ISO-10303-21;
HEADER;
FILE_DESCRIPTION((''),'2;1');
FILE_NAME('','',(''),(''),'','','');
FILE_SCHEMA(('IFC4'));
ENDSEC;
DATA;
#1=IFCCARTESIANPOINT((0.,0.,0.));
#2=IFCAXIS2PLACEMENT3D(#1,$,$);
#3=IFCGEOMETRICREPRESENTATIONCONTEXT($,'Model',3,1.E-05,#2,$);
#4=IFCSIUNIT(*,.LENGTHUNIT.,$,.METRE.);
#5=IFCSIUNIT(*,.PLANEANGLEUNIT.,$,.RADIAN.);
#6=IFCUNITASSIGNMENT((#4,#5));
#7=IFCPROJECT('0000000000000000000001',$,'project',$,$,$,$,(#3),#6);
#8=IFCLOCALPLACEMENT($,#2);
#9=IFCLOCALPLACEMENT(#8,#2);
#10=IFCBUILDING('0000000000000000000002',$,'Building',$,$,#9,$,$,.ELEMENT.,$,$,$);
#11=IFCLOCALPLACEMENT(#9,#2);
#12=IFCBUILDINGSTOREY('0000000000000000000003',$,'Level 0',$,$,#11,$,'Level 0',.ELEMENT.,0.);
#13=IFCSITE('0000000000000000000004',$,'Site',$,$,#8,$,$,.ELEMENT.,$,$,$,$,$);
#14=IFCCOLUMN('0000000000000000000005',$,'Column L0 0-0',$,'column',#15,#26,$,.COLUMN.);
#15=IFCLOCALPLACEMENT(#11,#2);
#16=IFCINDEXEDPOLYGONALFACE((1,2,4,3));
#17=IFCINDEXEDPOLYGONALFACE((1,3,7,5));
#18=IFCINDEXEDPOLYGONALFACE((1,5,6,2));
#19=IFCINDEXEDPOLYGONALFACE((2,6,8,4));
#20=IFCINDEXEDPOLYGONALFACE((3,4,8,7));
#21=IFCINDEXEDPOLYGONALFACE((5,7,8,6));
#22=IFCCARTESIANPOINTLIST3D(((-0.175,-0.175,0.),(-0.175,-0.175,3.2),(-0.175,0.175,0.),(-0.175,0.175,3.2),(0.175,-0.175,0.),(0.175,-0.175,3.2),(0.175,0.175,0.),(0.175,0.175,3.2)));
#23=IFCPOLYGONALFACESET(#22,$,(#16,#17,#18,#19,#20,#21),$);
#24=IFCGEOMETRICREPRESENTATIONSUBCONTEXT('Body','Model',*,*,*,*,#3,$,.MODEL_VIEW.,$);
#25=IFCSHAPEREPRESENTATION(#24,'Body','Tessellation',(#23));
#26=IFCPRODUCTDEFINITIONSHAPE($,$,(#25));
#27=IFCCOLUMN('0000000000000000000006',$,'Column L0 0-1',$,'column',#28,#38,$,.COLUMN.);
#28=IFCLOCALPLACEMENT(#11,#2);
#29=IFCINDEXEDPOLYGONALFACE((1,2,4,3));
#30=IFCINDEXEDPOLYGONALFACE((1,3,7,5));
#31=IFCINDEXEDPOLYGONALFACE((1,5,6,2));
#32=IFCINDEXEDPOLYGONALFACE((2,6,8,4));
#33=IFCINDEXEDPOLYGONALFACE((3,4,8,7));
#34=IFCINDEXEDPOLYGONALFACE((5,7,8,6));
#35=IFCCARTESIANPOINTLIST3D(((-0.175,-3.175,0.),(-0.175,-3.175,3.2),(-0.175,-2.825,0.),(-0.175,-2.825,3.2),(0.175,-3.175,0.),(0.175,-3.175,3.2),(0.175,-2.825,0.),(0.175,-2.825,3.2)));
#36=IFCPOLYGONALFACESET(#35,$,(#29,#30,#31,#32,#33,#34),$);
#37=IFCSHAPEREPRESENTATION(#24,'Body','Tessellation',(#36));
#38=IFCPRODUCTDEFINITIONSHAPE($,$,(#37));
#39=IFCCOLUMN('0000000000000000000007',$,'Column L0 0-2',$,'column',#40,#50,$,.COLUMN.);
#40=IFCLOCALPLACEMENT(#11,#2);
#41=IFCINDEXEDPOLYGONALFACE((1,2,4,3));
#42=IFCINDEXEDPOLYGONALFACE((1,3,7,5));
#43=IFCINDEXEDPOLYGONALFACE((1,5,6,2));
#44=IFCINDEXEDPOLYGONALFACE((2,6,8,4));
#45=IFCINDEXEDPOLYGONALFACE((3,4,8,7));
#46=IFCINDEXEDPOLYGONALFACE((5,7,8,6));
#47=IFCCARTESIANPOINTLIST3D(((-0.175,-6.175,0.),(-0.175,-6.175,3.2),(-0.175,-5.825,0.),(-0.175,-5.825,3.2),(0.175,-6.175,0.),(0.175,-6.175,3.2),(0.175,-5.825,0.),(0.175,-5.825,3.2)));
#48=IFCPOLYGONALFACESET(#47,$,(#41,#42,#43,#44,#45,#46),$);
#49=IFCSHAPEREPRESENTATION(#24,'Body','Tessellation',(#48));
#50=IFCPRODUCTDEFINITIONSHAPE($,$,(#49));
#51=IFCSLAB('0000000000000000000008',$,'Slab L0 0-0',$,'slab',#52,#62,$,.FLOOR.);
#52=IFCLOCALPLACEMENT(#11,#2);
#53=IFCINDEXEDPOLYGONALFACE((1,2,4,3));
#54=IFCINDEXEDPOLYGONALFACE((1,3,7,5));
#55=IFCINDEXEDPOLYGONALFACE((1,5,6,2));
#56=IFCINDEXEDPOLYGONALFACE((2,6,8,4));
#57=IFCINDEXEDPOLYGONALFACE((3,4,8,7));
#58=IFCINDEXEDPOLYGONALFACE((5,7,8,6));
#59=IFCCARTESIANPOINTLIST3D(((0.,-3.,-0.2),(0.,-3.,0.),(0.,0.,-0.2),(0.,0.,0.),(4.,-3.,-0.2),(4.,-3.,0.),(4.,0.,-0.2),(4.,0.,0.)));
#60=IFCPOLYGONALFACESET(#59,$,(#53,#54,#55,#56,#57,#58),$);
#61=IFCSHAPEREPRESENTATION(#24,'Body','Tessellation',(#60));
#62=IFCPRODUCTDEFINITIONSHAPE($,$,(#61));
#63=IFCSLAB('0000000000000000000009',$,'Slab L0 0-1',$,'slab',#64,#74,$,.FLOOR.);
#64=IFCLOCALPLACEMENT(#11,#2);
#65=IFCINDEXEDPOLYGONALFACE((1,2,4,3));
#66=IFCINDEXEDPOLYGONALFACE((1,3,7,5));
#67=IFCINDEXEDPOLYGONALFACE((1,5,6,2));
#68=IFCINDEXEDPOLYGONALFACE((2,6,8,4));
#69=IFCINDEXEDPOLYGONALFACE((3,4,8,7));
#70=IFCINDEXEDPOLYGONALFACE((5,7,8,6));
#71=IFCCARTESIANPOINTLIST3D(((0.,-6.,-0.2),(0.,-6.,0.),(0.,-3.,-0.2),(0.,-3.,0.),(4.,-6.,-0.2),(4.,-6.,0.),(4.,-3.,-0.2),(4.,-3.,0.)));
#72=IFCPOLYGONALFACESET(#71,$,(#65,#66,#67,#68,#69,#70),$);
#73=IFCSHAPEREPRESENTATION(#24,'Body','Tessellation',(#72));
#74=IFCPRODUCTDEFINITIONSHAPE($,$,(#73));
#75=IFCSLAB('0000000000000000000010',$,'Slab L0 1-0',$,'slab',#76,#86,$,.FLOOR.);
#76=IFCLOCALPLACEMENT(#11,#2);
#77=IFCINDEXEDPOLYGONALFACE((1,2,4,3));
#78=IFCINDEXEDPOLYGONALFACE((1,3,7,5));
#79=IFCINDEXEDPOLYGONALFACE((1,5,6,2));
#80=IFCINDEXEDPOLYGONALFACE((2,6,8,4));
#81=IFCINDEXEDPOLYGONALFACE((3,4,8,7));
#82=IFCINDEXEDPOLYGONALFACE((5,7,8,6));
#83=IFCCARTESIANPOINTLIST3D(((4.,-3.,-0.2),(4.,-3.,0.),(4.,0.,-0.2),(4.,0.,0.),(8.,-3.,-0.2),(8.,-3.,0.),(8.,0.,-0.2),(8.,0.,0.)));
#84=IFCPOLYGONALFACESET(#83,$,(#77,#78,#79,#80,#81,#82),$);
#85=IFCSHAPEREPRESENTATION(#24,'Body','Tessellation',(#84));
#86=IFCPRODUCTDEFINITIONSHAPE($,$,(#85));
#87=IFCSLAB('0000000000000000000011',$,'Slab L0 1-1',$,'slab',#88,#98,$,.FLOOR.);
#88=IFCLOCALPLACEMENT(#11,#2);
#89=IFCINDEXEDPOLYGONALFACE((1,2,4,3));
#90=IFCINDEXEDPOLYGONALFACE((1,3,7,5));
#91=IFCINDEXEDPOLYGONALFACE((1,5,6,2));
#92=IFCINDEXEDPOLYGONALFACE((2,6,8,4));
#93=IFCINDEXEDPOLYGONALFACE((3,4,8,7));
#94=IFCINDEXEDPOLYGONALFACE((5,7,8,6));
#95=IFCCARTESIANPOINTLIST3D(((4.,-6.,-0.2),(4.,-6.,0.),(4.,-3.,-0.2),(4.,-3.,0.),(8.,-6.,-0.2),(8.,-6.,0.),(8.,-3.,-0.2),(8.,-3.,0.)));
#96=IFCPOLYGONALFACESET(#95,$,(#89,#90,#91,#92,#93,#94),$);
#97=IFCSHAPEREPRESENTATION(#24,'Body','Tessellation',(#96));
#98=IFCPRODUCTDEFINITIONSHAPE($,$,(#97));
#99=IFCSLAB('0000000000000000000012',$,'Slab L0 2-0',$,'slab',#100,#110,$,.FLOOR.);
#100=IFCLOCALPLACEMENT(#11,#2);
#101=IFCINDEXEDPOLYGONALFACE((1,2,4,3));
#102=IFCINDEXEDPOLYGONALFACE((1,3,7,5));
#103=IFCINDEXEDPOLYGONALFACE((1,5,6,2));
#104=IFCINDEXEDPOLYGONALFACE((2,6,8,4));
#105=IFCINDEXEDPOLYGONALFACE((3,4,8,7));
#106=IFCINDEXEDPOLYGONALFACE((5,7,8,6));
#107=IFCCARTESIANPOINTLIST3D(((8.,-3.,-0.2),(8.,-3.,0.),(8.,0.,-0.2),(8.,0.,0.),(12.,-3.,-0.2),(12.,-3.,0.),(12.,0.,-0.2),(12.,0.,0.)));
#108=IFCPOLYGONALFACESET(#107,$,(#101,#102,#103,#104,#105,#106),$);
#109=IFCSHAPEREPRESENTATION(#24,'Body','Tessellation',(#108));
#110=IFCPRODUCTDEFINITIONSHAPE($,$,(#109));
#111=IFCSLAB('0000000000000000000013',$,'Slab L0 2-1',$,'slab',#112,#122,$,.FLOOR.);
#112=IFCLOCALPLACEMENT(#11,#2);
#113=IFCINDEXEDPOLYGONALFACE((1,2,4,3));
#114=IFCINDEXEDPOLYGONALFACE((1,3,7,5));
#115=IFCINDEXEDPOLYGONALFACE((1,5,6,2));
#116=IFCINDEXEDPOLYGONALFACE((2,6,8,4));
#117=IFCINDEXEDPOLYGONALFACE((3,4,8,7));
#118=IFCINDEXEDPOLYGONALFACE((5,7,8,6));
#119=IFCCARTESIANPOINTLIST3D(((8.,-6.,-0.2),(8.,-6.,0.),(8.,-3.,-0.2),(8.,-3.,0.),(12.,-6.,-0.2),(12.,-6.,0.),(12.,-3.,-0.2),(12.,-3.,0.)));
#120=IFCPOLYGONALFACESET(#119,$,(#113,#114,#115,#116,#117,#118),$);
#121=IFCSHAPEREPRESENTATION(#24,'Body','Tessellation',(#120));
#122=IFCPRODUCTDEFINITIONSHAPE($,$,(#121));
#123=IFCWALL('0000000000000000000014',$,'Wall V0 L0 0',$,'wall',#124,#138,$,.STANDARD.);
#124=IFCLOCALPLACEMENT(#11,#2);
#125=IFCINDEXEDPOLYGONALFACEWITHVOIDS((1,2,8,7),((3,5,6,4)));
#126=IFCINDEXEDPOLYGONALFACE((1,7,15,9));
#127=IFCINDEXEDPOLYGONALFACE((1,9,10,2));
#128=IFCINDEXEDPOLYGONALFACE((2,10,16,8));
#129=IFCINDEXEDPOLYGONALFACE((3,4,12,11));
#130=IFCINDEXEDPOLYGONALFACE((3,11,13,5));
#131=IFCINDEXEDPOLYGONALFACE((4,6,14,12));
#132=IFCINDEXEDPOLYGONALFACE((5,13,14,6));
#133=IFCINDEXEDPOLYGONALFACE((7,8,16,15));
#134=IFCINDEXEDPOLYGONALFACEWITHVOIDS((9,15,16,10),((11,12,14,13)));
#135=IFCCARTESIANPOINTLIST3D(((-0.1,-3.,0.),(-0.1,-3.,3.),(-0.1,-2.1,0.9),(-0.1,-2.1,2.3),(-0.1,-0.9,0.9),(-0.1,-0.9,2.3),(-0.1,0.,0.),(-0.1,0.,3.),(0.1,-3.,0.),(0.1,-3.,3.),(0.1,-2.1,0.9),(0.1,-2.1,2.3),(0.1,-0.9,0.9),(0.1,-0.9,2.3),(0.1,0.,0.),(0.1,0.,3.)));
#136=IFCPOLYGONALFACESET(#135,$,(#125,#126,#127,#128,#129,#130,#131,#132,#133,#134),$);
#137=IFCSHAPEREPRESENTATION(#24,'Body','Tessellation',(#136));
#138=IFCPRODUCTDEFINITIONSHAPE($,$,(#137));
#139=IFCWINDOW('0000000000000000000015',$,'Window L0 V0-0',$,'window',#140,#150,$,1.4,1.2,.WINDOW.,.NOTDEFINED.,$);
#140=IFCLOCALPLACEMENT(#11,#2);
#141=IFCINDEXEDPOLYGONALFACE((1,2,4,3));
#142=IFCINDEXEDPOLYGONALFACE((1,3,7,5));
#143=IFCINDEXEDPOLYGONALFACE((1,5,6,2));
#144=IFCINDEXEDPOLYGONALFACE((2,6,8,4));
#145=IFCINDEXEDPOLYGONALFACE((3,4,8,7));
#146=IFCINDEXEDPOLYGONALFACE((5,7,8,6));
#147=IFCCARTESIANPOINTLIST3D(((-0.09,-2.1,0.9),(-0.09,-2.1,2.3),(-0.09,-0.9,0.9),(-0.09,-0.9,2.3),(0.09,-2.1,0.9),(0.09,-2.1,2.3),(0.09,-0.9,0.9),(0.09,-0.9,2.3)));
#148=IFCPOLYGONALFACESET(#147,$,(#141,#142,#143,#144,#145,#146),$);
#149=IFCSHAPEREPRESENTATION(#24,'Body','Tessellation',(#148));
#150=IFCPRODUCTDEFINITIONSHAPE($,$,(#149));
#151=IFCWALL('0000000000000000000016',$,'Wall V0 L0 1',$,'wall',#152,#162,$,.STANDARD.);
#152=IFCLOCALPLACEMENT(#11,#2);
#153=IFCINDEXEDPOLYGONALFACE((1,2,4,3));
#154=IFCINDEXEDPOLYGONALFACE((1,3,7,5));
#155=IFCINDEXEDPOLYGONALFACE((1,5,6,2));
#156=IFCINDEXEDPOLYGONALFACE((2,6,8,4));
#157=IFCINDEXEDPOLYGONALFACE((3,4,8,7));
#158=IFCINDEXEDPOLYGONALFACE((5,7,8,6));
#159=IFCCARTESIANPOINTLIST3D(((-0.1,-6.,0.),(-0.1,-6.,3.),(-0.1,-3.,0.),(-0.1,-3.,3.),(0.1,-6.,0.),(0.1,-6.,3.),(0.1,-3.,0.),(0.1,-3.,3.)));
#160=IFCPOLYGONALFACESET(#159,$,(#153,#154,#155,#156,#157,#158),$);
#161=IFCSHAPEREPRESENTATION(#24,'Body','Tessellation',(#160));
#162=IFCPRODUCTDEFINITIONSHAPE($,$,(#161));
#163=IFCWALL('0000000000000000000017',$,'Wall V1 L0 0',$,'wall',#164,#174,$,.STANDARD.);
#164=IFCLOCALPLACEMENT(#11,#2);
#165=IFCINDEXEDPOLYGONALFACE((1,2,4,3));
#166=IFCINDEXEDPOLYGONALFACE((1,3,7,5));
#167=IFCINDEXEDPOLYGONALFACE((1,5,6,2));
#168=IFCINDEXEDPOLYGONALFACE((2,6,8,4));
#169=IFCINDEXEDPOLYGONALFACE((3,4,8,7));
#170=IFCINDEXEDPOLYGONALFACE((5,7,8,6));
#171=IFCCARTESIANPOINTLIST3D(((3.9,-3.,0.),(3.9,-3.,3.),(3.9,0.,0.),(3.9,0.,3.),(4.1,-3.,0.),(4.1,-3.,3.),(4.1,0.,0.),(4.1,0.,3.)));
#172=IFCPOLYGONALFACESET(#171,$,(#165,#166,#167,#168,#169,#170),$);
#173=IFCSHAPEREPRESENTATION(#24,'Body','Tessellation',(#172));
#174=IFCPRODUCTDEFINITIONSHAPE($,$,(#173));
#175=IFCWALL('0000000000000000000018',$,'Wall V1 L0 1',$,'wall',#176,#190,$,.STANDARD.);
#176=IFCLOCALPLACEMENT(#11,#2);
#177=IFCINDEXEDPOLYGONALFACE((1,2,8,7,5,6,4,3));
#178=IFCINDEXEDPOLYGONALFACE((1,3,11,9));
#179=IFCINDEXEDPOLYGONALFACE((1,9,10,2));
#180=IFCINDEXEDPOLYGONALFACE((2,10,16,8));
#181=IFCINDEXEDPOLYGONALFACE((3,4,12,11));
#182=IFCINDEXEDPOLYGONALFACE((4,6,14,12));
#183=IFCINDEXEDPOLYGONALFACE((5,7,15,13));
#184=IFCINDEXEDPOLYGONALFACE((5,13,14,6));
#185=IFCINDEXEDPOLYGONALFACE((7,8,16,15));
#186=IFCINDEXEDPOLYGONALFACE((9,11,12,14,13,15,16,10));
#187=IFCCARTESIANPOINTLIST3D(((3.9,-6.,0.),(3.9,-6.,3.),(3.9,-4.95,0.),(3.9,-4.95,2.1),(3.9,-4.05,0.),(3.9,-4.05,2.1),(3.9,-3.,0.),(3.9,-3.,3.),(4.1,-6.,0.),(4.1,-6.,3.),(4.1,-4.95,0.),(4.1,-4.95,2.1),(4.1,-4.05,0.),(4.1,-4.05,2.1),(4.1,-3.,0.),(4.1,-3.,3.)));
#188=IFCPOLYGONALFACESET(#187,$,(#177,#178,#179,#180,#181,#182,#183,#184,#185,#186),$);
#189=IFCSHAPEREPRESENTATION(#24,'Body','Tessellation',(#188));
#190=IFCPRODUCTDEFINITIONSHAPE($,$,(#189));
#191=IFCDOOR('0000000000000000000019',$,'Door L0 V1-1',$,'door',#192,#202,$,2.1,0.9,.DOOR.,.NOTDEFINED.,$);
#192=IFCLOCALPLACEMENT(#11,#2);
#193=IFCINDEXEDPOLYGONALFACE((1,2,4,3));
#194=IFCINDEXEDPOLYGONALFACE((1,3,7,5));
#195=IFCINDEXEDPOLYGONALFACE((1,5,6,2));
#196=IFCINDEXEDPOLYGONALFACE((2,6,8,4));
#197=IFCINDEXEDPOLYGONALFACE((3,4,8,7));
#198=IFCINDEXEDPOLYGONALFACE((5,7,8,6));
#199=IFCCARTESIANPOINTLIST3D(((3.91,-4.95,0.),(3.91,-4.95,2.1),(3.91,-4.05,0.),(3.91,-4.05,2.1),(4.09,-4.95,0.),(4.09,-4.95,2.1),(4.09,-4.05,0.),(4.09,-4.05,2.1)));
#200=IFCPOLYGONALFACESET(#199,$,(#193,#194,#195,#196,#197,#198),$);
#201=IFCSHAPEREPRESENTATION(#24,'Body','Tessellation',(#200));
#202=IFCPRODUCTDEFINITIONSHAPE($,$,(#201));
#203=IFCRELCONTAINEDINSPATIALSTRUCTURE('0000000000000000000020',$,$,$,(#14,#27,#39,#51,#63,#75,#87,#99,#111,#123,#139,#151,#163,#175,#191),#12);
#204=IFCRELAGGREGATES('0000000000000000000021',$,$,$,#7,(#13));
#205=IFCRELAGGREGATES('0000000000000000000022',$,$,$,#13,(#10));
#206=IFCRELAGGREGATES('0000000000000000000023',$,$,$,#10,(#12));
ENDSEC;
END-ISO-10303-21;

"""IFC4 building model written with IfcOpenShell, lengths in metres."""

from ifc_helpers import new_model, si_unit, frame, frame_2d, origin, origin_2d, place, context, subcontext, project, spatial, polyline, rectangle, outline, extrude, element, fill, save


model = new_model("IFC4")

# Units and contexts
model_context = context("Model", 3, precision=1e-05, world=origin())
body_context = subcontext(model_context, "Body", "Model", "MODEL_VIEW")
ifc_project = project(units=[si_unit("LENGTHUNIT", "METRE"), si_unit("PLANEANGLEUNIT", "RADIAN")], contexts=[model_context])

# Site, building, storey
site_placement = place(None, origin())
site = spatial("IfcSite", under=ifc_project, at=site_placement, Name="Site", CompositionType="ELEMENT")
building_placement = place(site_placement, origin())
building = spatial("IfcBuilding", under=site, at=building_placement, Name="Building", CompositionType="ELEMENT")
storey_placement = place(building_placement, origin())
storey = spatial("IfcBuildingStorey", under=building, at=storey_placement, Name="Level 0", LongName="Level 0", CompositionType="ELEMENT", Elevation=0.0)

# Columns
for number, where, name in (
    (1, (0.0, 0.0, 0.0), "Column L0 0-0"),
    (2, (0.0, -3.0, 0.0), "Column L0 0-1"),
    (3, (0.0, -6.0, 0.0), "Column L0 0-2"),
):
    element("IfcColumn", number, at=place(storey_placement, frame(where)), inside=storey, Name=name, ObjectType="column", PredefinedType="COLUMN", context=body_context, shape_type="SweptSolid", body=[
        extrude(rectangle(XDim=0.35, YDim=0.35, at=origin_2d()), origin(), (0.0, 0.0, 1.0), 3.2),
    ])

# Slabs
slab_1_placement = place(storey_placement, frame((0.0, 0.0, -0.2)))
element("IfcSlab", 4, at=slab_1_placement, inside=storey, Name="Slab L0 0-0", ObjectType="slab", PredefinedType="FLOOR", context=body_context, shape_type="SweptSolid", body=[
    extrude(outline(polyline([(0.0, -3.0), (4.0, -3.0), (4.0, 0.0), (0.0, 0.0), (0.0, -3.0)])), origin(), (0.0, 0.0, 1.0), 0.2),
])
slab_2_placement = place(storey_placement, frame((0.0, 0.0, -0.2)))
element("IfcSlab", 5, at=slab_2_placement, inside=storey, Name="Slab L0 0-1", ObjectType="slab", PredefinedType="FLOOR", context=body_context, shape_type="SweptSolid", body=[
    extrude(outline(polyline([(0.0, -6.0), (4.0, -6.0), (4.0, -3.0), (0.0, -3.0), (0.0, -6.0)])), origin(), (0.0, 0.0, 1.0), 0.2),
])
slab_3_placement = place(storey_placement, frame((0.0, 0.0, -0.2)))
element("IfcSlab", 6, at=slab_3_placement, inside=storey, Name="Slab L0 1-0", ObjectType="slab", PredefinedType="FLOOR", context=body_context, shape_type="SweptSolid", body=[
    extrude(outline(polyline([(4.0, -3.0), (8.0, -3.0), (8.0, 0.0), (4.0, 0.0), (4.0, -3.0)])), origin(), (0.0, 0.0, 1.0), 0.2),
])
slab_4_placement = place(storey_placement, frame((0.0, 0.0, -0.2)))
element("IfcSlab", 7, at=slab_4_placement, inside=storey, Name="Slab L0 1-1", ObjectType="slab", PredefinedType="FLOOR", context=body_context, shape_type="SweptSolid", body=[
    extrude(outline(polyline([(4.0, -6.0), (8.0, -6.0), (8.0, -3.0), (4.0, -3.0), (4.0, -6.0)])), origin(), (0.0, 0.0, 1.0), 0.2),
])
slab_5_placement = place(storey_placement, frame((0.0, 0.0, -0.2)))
element("IfcSlab", 8, at=slab_5_placement, inside=storey, Name="Slab L0 2-0", ObjectType="slab", PredefinedType="FLOOR", context=body_context, shape_type="SweptSolid", body=[
    extrude(outline(polyline([(8.0, -3.0), (12.0, -3.0), (12.0, 0.0), (8.0, 0.0), (8.0, -3.0)])), origin(), (0.0, 0.0, 1.0), 0.2),
])
slab_6_placement = place(storey_placement, frame((0.0, 0.0, -0.2)))
element("IfcSlab", 9, at=slab_6_placement, inside=storey, Name="Slab L0 2-1", ObjectType="slab", PredefinedType="FLOOR", context=body_context, shape_type="SweptSolid", body=[
    extrude(outline(polyline([(8.0, -6.0), (12.0, -6.0), (12.0, -3.0), (8.0, -3.0), (8.0, -6.0)])), origin(), (0.0, 0.0, 1.0), 0.2),
])

# Wall, opening, window
wall_1_placement = place(storey_placement, frame((0.0, 0.0, 0.0), z_axis=(0.0, 0.0, 1.0), x_axis=(0.0, -1.0, 0.0)))
wall_1 = element("IfcWall", 10, at=wall_1_placement, inside=storey, Name="Wall V0 L0 0", ObjectType="wall", PredefinedType="STANDARD", context=body_context, shape_type="SweptSolid", body=[
    extrude(rectangle(XDim=3.0, YDim=0.2, at=frame_2d((1.5, 0.0))), origin(), (0.0, 0.0, 1.0), 3.0),
])
opening_1_placement = place(storey_placement, frame((0.0, -1.5, 0.9), z_axis=(0.0, 0.0, 1.0), x_axis=(0.0, -1.0, 0.0)))
opening_1 = element("IfcOpeningElement", 11, at=opening_1_placement, cuts=wall_1, ObjectType="Opening", PredefinedType="OPENING", context=body_context, shape_type="SweptSolid", body=[
    extrude(rectangle(XDim=1.2, YDim=0.22, at=origin_2d()), origin(), (0.0, 0.0, 1.0), 1.4),
])
window_1_placement = place(storey_placement, frame((0.0, -1.5, 0.9), z_axis=(0.0, 0.0, 1.0), x_axis=(0.0, -1.0, 0.0)))
window_1 = element("IfcWindow", 12, at=window_1_placement, inside=storey, Name="Window L0 V0-0", ObjectType="window", OverallHeight=1.4, OverallWidth=1.2, PartitioningType="NOTDEFINED", PredefinedType="WINDOW", context=body_context, shape_type="SweptSolid", body=[
    extrude(rectangle(XDim=1.2, YDim=0.18, at=origin_2d()), origin(), (0.0, 0.0, 1.0), 1.4),
])
fill(opening_1, window_1)

# Walls
for number, where, z_axis, x_axis, name in (
    (13, (0.0, -3.0, 0.0), (0.0, 0.0, 1.0), (0.0, -1.0, 0.0), "Wall V0 L0 1"),
    (14, (4.0, 0.0, 0.0), (0.0, 0.0, 1.0), (0.0, -1.0, 0.0), "Wall V1 L0 0"),
):
    element("IfcWall", number, at=place(storey_placement, frame(where, z_axis=z_axis, x_axis=x_axis)), inside=storey, Name=name, ObjectType="wall", PredefinedType="STANDARD", context=body_context, shape_type="SweptSolid", body=[
        extrude(rectangle(XDim=3.0, YDim=0.2, at=frame_2d((1.5, 0.0))), origin(), (0.0, 0.0, 1.0), 3.0),
    ])

# Wall, opening, door
wall_2_placement = place(storey_placement, frame((4.0, -3.0, 0.0), z_axis=(0.0, 0.0, 1.0), x_axis=(0.0, -1.0, 0.0)))
wall_2 = element("IfcWall", 15, at=wall_2_placement, inside=storey, Name="Wall V1 L0 1", ObjectType="wall", PredefinedType="STANDARD", context=body_context, shape_type="SweptSolid", body=[
    extrude(rectangle(XDim=3.0, YDim=0.2, at=frame_2d((1.5, 0.0))), origin(), (0.0, 0.0, 1.0), 3.0),
])
opening_2_placement = place(storey_placement, frame((4.0, -4.5, 0.0), z_axis=(0.0, 0.0, 1.0), x_axis=(0.0, -1.0, 0.0)))
opening_2 = element("IfcOpeningElement", 16, at=opening_2_placement, cuts=wall_2, ObjectType="Opening", PredefinedType="OPENING", context=body_context, shape_type="SweptSolid", body=[
    extrude(rectangle(XDim=0.9, YDim=0.22, at=origin_2d()), origin(), (0.0, 0.0, 1.0), 2.1),
])
door_placement = place(storey_placement, frame((4.0, -4.5, 0.0), z_axis=(0.0, 0.0, 1.0), x_axis=(0.0, -1.0, 0.0)))
door = element("IfcDoor", 17, at=door_placement, inside=storey, Name="Door L0 V1-1", ObjectType="door", OperationType="NOTDEFINED", OverallHeight=2.1, OverallWidth=0.9, PredefinedType="DOOR", context=body_context, shape_type="SweptSolid", body=[
    extrude(rectangle(XDim=0.9, YDim=0.18, at=origin_2d()), origin(), (0.0, 0.0, 1.0), 2.1),
])
fill(opening_2, door)

save(model, "model.ifc")
